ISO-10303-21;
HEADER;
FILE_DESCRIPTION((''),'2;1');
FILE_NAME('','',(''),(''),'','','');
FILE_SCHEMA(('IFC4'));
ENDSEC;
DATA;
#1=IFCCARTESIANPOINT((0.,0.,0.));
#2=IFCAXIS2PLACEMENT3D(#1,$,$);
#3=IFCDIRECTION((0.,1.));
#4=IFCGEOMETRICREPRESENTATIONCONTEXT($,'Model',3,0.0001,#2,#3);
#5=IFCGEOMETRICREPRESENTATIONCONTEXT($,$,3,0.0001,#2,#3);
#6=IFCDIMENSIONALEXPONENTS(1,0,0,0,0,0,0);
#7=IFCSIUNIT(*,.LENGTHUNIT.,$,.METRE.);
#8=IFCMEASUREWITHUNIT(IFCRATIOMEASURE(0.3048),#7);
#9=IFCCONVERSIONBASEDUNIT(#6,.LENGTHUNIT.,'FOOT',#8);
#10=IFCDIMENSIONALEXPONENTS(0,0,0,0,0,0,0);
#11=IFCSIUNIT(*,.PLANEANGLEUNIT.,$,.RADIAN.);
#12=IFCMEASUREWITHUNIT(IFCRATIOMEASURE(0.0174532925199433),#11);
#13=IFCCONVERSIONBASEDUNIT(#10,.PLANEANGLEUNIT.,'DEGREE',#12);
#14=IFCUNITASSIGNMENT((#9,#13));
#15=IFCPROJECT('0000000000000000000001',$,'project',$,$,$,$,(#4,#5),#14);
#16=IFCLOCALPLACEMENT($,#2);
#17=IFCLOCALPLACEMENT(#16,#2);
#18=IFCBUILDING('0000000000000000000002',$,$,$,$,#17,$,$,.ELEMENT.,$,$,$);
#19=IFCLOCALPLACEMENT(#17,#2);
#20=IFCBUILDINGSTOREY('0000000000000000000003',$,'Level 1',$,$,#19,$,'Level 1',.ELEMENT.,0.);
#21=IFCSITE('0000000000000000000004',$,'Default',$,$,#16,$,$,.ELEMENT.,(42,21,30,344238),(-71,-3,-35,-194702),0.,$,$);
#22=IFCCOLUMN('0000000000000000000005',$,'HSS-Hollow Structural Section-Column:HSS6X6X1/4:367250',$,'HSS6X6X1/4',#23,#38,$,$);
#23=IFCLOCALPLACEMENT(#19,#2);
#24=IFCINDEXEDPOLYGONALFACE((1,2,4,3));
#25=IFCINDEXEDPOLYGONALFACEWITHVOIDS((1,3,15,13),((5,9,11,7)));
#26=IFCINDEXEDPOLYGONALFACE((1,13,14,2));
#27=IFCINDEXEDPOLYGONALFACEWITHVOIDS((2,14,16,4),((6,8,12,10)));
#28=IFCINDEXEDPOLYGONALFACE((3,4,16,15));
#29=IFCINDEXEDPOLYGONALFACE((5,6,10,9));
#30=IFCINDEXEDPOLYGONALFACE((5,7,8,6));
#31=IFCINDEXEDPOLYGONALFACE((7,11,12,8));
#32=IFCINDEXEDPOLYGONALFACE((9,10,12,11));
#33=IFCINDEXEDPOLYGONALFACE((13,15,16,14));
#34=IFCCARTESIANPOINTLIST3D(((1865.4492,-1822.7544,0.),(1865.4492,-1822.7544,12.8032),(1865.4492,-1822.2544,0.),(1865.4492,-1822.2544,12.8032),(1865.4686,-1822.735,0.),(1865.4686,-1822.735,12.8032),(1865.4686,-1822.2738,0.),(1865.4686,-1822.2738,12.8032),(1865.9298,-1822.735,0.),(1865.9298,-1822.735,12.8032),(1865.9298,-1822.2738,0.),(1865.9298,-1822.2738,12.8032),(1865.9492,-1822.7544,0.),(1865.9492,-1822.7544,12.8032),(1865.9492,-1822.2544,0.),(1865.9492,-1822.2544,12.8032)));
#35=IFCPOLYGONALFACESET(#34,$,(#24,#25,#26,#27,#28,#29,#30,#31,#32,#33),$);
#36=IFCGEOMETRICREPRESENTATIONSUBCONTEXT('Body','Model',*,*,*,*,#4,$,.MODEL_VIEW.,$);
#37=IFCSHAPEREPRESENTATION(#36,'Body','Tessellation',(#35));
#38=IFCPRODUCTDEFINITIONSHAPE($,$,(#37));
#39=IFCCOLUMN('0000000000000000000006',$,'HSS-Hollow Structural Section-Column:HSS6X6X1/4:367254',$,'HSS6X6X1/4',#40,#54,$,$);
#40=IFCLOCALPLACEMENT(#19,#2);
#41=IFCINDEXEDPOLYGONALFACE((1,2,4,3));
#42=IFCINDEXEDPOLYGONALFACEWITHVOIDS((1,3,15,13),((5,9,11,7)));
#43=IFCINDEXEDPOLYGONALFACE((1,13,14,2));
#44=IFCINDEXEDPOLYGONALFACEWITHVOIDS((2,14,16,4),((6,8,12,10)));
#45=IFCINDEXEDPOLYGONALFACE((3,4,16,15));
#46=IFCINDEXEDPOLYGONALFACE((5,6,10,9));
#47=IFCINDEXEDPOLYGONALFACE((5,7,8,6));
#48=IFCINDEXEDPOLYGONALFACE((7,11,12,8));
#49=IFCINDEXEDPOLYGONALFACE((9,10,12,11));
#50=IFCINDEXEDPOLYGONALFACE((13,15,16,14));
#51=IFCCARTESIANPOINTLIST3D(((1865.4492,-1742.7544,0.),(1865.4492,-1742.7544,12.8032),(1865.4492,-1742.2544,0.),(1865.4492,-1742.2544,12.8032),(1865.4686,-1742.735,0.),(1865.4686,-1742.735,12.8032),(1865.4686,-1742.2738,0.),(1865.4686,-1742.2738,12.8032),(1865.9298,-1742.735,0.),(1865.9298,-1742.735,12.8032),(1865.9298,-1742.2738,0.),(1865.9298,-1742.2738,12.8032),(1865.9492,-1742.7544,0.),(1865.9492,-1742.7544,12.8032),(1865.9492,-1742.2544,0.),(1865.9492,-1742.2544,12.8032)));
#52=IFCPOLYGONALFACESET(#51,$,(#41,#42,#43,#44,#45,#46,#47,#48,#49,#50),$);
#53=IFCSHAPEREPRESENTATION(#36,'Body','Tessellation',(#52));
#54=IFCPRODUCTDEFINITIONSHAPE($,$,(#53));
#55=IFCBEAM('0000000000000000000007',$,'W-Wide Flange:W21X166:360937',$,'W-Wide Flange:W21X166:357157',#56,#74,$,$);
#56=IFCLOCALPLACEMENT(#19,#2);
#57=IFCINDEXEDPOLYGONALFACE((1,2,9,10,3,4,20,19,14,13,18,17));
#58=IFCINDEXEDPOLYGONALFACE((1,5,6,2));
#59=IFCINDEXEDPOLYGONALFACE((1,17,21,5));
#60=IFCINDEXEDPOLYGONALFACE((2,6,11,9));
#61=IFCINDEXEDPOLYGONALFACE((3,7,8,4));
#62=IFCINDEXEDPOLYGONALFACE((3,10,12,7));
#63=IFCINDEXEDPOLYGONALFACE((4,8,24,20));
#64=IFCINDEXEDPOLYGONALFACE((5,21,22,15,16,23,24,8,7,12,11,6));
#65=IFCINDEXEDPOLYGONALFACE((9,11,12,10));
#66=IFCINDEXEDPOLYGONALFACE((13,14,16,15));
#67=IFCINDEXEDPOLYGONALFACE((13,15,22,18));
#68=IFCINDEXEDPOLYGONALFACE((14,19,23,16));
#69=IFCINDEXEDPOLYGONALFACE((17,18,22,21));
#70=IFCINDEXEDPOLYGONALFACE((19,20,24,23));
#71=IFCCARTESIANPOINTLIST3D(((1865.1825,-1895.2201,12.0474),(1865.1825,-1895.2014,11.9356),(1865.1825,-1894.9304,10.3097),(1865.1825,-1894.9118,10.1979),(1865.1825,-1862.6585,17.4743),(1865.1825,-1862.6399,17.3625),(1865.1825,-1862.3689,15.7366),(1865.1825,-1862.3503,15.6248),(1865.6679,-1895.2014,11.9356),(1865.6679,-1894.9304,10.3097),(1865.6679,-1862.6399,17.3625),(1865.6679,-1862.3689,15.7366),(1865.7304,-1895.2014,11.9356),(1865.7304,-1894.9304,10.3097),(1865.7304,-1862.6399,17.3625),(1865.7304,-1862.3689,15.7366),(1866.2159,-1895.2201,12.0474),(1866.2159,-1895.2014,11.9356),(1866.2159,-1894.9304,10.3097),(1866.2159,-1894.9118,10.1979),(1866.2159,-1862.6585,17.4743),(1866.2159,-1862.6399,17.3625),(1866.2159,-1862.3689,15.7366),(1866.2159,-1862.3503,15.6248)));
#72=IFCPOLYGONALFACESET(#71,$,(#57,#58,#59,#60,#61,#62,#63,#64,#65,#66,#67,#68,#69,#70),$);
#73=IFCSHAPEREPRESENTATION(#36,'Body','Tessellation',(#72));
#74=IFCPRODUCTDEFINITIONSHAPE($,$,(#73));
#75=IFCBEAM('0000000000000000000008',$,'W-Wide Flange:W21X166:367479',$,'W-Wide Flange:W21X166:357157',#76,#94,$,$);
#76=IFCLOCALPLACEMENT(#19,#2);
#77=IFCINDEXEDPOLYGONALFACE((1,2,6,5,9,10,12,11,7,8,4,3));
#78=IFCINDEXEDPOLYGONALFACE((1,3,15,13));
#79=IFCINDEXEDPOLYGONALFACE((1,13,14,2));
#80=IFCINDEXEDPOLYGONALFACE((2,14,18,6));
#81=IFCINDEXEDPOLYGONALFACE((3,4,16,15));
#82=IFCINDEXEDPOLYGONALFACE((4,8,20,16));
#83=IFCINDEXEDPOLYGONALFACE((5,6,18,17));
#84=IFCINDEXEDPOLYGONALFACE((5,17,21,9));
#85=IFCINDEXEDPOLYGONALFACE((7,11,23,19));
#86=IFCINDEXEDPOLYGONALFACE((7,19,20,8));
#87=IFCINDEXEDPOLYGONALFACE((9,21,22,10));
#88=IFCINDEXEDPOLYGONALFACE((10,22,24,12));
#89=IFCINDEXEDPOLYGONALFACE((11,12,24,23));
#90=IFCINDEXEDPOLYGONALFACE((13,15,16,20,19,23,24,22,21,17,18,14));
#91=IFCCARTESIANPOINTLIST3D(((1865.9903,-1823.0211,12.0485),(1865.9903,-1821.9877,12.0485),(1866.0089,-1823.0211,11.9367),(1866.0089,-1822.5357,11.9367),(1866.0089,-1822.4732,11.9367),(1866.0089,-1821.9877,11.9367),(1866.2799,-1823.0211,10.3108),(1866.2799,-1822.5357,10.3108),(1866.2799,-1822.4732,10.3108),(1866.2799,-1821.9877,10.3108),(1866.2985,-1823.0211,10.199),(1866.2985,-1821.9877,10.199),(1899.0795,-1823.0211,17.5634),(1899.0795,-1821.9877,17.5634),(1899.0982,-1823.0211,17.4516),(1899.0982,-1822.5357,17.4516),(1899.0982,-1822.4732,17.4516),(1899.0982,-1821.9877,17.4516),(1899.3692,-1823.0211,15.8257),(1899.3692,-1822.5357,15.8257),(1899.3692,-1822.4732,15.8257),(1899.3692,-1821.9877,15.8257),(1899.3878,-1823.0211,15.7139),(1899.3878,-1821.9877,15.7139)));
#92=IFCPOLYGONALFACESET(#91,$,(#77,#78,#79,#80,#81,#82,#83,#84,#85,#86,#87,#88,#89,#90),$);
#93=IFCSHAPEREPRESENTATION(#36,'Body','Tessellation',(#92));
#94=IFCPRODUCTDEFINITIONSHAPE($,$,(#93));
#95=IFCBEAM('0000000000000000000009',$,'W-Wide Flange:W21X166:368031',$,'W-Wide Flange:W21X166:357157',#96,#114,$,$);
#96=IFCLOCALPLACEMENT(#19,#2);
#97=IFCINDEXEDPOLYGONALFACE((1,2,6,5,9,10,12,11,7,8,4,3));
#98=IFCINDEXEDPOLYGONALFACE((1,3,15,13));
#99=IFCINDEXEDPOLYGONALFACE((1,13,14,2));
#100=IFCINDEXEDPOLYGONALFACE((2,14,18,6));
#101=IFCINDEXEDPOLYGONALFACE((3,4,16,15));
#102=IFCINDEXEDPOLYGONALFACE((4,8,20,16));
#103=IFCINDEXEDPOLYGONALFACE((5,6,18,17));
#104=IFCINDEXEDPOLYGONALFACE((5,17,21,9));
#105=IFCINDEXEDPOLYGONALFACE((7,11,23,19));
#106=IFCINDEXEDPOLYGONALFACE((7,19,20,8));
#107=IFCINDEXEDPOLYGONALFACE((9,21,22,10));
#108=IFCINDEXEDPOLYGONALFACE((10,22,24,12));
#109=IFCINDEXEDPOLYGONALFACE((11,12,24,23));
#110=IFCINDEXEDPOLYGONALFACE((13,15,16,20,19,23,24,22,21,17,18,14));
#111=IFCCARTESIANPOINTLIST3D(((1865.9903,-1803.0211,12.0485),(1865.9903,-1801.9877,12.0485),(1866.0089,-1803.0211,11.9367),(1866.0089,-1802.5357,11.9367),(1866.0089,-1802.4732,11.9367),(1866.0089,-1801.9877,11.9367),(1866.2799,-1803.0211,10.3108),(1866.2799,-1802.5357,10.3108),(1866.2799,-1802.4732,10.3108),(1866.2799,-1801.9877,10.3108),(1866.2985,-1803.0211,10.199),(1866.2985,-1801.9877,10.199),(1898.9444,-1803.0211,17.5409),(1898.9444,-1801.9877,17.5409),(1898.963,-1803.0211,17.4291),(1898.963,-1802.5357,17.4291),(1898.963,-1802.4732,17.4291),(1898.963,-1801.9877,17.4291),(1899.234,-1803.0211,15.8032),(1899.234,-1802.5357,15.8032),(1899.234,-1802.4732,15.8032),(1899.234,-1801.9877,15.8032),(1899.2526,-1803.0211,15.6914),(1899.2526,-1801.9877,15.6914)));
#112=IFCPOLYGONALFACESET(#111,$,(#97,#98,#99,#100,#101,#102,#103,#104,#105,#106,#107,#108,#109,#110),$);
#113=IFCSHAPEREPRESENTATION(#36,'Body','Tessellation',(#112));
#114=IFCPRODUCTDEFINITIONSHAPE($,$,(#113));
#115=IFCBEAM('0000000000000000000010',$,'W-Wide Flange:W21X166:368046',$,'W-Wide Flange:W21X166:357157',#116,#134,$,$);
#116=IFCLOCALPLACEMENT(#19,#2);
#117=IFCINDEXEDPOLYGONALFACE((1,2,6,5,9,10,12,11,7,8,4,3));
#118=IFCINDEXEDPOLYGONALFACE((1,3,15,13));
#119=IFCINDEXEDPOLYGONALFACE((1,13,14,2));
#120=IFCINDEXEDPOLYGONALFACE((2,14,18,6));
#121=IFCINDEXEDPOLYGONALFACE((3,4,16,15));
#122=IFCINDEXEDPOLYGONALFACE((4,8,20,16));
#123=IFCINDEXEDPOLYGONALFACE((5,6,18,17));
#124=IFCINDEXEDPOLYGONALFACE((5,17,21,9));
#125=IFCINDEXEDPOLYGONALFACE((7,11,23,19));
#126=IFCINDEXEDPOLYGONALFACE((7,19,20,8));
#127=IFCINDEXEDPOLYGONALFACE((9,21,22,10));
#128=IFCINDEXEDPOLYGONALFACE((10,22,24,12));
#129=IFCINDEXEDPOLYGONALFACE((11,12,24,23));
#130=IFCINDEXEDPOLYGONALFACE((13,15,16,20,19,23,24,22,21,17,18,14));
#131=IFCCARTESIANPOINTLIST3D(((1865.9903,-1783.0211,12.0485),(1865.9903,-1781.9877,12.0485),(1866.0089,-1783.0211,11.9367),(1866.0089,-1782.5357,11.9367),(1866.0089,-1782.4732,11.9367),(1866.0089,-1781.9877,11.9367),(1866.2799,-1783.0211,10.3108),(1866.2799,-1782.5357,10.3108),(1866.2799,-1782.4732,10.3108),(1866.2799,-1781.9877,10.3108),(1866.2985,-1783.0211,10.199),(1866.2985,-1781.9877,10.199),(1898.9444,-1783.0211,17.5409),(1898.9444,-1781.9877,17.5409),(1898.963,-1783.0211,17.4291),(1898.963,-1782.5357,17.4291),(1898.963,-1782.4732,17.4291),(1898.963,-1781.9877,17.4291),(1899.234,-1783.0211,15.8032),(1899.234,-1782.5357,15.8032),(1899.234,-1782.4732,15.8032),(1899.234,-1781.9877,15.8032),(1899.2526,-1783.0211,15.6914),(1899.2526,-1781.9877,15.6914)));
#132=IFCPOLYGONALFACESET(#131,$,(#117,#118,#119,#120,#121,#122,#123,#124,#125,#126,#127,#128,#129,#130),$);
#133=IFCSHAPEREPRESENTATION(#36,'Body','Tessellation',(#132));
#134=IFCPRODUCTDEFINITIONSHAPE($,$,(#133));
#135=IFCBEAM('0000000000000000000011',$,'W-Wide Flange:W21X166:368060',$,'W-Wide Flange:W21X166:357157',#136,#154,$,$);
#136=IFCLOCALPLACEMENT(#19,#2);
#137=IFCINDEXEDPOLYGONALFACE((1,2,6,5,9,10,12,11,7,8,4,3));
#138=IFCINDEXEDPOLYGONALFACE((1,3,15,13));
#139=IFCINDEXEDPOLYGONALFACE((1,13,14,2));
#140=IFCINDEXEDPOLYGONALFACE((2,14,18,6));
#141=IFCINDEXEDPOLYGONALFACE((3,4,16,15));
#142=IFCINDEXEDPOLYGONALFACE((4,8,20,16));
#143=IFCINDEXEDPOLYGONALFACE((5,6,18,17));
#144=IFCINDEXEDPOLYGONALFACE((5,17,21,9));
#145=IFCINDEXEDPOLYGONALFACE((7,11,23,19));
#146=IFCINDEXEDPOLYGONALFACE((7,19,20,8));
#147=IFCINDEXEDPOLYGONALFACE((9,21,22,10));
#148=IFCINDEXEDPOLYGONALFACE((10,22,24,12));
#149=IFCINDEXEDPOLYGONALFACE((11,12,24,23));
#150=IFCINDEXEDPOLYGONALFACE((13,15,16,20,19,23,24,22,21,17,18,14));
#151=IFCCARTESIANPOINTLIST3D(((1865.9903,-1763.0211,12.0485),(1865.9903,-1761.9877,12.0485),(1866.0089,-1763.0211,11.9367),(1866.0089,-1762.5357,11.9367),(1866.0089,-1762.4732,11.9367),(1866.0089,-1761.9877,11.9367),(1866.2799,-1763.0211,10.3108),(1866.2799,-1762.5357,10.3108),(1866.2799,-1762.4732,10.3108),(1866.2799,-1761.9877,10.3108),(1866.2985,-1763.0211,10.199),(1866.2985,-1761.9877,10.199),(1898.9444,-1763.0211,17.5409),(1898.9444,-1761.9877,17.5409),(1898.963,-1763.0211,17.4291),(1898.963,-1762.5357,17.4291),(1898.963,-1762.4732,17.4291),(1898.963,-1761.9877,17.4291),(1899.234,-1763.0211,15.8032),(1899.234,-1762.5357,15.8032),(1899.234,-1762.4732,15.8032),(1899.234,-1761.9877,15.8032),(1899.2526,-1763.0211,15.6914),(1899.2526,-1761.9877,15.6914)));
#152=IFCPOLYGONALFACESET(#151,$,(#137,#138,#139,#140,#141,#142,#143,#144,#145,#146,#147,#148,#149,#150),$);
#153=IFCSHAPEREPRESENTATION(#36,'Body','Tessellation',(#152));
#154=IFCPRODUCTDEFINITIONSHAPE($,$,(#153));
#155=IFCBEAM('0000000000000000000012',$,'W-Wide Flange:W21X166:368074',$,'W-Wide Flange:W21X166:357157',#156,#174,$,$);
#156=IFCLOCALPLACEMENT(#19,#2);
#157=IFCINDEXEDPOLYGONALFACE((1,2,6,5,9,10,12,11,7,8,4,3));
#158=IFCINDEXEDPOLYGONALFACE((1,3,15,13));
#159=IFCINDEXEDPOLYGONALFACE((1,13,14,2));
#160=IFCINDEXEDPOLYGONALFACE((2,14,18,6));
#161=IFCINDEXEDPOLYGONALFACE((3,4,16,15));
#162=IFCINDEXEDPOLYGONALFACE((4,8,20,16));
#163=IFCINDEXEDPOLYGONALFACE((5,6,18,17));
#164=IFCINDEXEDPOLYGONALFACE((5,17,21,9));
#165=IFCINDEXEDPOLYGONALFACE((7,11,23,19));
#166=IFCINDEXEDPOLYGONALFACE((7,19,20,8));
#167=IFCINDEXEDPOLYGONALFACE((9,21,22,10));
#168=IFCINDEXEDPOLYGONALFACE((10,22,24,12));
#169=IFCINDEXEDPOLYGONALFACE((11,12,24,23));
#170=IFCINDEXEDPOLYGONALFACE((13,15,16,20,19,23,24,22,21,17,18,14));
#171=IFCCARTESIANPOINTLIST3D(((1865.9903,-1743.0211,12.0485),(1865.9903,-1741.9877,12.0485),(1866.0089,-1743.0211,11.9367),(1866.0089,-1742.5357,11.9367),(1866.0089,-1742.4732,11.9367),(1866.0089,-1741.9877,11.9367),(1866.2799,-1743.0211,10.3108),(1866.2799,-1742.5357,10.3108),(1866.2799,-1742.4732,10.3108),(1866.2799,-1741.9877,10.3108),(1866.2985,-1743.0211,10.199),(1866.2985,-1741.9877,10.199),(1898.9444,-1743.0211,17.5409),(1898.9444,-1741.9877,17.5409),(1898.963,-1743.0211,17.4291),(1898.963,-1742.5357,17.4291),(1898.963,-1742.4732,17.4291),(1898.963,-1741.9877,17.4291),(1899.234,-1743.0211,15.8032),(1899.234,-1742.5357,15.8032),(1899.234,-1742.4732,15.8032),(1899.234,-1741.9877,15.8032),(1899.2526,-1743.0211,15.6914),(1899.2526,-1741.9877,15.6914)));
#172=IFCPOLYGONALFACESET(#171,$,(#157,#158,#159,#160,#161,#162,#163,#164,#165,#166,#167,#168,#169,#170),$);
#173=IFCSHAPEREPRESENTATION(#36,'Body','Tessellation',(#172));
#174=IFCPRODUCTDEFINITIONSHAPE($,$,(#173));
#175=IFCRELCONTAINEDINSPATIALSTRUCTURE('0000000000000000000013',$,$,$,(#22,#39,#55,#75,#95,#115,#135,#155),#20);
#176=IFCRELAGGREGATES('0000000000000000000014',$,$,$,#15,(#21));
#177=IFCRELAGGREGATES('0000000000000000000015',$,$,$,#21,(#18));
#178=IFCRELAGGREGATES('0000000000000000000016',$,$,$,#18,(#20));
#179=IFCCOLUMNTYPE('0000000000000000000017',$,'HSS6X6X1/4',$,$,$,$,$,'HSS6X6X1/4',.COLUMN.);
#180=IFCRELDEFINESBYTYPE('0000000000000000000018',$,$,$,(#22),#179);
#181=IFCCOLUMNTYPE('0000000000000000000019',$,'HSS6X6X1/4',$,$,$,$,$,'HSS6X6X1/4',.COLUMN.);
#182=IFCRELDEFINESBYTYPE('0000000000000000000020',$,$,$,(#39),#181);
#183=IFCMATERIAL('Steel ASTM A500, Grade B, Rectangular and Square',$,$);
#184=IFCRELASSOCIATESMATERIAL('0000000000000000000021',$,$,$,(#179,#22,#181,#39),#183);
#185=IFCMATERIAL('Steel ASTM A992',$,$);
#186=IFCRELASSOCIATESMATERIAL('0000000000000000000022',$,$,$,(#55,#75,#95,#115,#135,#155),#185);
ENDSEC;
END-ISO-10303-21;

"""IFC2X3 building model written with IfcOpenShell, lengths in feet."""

from ifc_helpers import new_model, entity, si_unit, converted_unit, direction, frame, frame_2d, origin, place, context, subcontext, project, spatial, polyline, i_section, outline, extrude, source, transform, mapped, material, type_object, type_shapes, element, save


model = new_model("IFC2X3")

# Units and contexts
model_context = context("Model", 3, precision=0.0001, world=origin(), true_north=direction((0.0, 1.0)))
context_of_model = context(None, 3, precision=0.0001, world=origin(), true_north=direction((0.0, 1.0)))
body_context = subcontext(model_context, "Body", "Model", "MODEL_VIEW")
ifc_project = project(units=[converted_unit("LENGTHUNIT", "FOOT", entity("IfcRatioMeasure", 0.3048), si_unit("LENGTHUNIT", "METRE"), dimensions=[1, 0, 0, 0, 0, 0, 0]), converted_unit("PLANEANGLEUNIT", "DEGREE", entity("IfcRatioMeasure", 0.0174532925199433), si_unit("PLANEANGLEUNIT", "RADIAN"), dimensions=[0, 0, 0, 0, 0, 0, 0])], contexts=[model_context, context_of_model])

# Site, building, storey
site_placement = place(None, origin())
site = spatial("IfcSite", under=ifc_project, at=site_placement, Name="Default", CompositionType="ELEMENT", RefLatitude=(42, 21, 30, 344238), RefLongitude=(-71, -3, -35, -194702), RefElevation=0.0)
building_placement = place(site_placement, origin())
building = spatial("IfcBuilding", under=site, at=building_placement, CompositionType="ELEMENT")
storey_placement = place(building_placement, origin())
storey = spatial("IfcBuildingStorey", under=building, at=storey_placement, Name="Level 1", LongName="Level 1", CompositionType="ELEMENT", Elevation=0.0)

# Columns
ifc_material_1 = material(Name="Steel ASTM A500, Grade B, Rectangular and Square")
ifc_material_2 = material(Name="Steel ASTM A992")
column_type_1 = type_object("IfcColumnType", Name="HSS6X6X1/4", ElementType="HSS6X6X1/4", PredefinedType="COLUMN", material=ifc_material_1)
shared_shape_1 = source(origin(), body_context, "Body", "SweptSolid", [
    extrude(outline(polyline([(-0.25, -0.25), (0.25, -0.25), (0.25, 0.25), (-0.25, 0.25), (-0.25, -0.25)]), holes=[polyline([(-0.2306, -0.2306), (-0.2306, 0.2306), (0.2306, 0.2306), (0.2306, -0.2306), (-0.2306, -0.2306)])]), frame((0.25, 0.25, 0.0)), (0.0, 0.0, 1.0), 12.8032),
])
type_shapes(column_type_1, [shared_shape_1])
column_1_placement = place(storey_placement, frame((1865.4492, -1822.7544, 0.0)))
element("IfcColumn", 1, at=column_1_placement, inside=storey, type_object=column_type_1, material=ifc_material_1, Name="HSS-Hollow Structural Section-Column:HSS6X6X1/4:367250", ObjectType="HSS6X6X1/4", context=body_context, shape_type="MappedRepresentation", body=[
    mapped(shared_shape_1, transform((0.0, 0.0, 0.0), scale=1.0)),
])
column_type_2 = type_object("IfcColumnType", Name="HSS6X6X1/4", ElementType="HSS6X6X1/4", PredefinedType="COLUMN", material=ifc_material_1)
shared_shape_2 = source(origin(), body_context, "Body", "SweptSolid", [
    extrude(outline(polyline([(-0.25, -0.25), (0.25, -0.25), (0.25, 0.25), (-0.25, 0.25), (-0.25, -0.25)]), holes=[polyline([(-0.2306, -0.2306), (-0.2306, 0.2306), (0.2306, 0.2306), (0.2306, -0.2306), (-0.2306, -0.2306)])]), frame((0.25, 0.25, 0.0)), (0.0, 0.0, 1.0), 12.8032),
])
type_shapes(column_type_2, [shared_shape_2])
column_2_placement = place(storey_placement, frame((1865.4492, -1742.7544, 0.0)))
element("IfcColumn", 2, at=column_2_placement, inside=storey, type_object=column_type_2, material=ifc_material_1, Name="HSS-Hollow Structural Section-Column:HSS6X6X1/4:367254", ObjectType="HSS6X6X1/4", context=body_context, shape_type="MappedRepresentation", body=[
    mapped(shared_shape_2, transform((0.0, 0.0, 0.0), scale=1.0)),
])

# Beams
beam_1_placement = place(storey_placement, frame((1865.6992, -1895.6585, 11.9743), z_axis=(0.0, -0.164399, 0.986394), x_axis=(0.0, 0.986394, 0.164399)))
element("IfcBeam", 3, at=beam_1_placement, inside=storey, material=ifc_material_2, Name="W-Wide Flange:W21X166:360937", ObjectType="W-Wide Flange:W21X166:357157", context=body_context, shape_type="SweptSolid", body=[
    extrude(i_section(OverallWidth=1.0333, OverallDepth=1.875, WebThickness=0.0625, FlangeThickness=0.1133, at=frame_2d((0.0, 0.0), x_axis=(0.0, 1.0))), frame((0.4445, 0.0, -0.9375), z_axis=(1.0, 0.0, 0.0), x_axis=(0.0, 0.0, -1.0)), (0.0, 0.0, 1.0), 33.0107),
])
beam_2_placement = place(storey_placement, frame((1865.8276, -1822.5044, 12.0214), z_axis=(-0.164399, 0.0, 0.986394), x_axis=(0.986394, 0.0, 0.164399)))
element("IfcBeam", 4, at=beam_2_placement, inside=storey, material=ifc_material_2, Name="W-Wide Flange:W21X166:367479", ObjectType="W-Wide Flange:W21X166:357157", context=body_context, shape_type="SweptSolid", body=[
    extrude(i_section(OverallWidth=1.0333, OverallDepth=1.875, WebThickness=0.0625, FlangeThickness=0.1133, at=frame_2d((0.0, 0.0), x_axis=(0.0, 1.0))), frame((0.165, 0.0, -0.9375), z_axis=(1.0, 0.0, 0.0), x_axis=(0.0, 0.0, -1.0)), (0.0, 0.0, 1.0), 33.5457),
])

# Beams
beam_3_placement = place(storey_placement, frame((1865.8276, -1802.5044, 12.0214), z_axis=(-0.164399, 0.0, 0.986394), x_axis=(0.986394, 0.0, 0.164399)))
element("IfcBeam", 5, at=beam_3_placement, inside=storey, material=ifc_material_2, Name="W-Wide Flange:W21X166:368031", ObjectType="W-Wide Flange:W21X166:357157", context=body_context, shape_type="SweptSolid", body=[
    extrude(i_section(OverallWidth=1.0333, OverallDepth=1.875, WebThickness=0.0625, FlangeThickness=0.1133, at=frame_2d((0.0, 0.0), x_axis=(0.0, 1.0))), frame((0.165, 0.0, -0.9375), z_axis=(1.0, 0.0, 0.0), x_axis=(0.0, 0.0, -1.0)), (0.0, 0.0, 1.0), 33.4087),
])
beam_4_placement = place(storey_placement, frame((1865.8276, -1782.5044, 12.0214), z_axis=(-0.164399, 0.0, 0.986394), x_axis=(0.986394, 0.0, 0.164399)))
element("IfcBeam", 6, at=beam_4_placement, inside=storey, material=ifc_material_2, Name="W-Wide Flange:W21X166:368046", ObjectType="W-Wide Flange:W21X166:357157", context=body_context, shape_type="SweptSolid", body=[
    extrude(i_section(OverallWidth=1.0333, OverallDepth=1.875, WebThickness=0.0625, FlangeThickness=0.1133, at=frame_2d((0.0, 0.0), x_axis=(0.0, 1.0))), frame((0.165, 0.0, -0.9375), z_axis=(1.0, 0.0, 0.0), x_axis=(0.0, 0.0, -1.0)), (0.0, 0.0, 1.0), 33.4087),
])
beam_5_placement = place(storey_placement, frame((1865.8276, -1762.5044, 12.0214), z_axis=(-0.164399, 0.0, 0.986394), x_axis=(0.986394, 0.0, 0.164399)))
element("IfcBeam", 7, at=beam_5_placement, inside=storey, material=ifc_material_2, Name="W-Wide Flange:W21X166:368060", ObjectType="W-Wide Flange:W21X166:357157", context=body_context, shape_type="SweptSolid", body=[
    extrude(i_section(OverallWidth=1.0333, OverallDepth=1.875, WebThickness=0.0625, FlangeThickness=0.1133, at=frame_2d((0.0, 0.0), x_axis=(0.0, 1.0))), frame((0.165, 0.0, -0.9375), z_axis=(1.0, 0.0, 0.0), x_axis=(0.0, 0.0, -1.0)), (0.0, 0.0, 1.0), 33.4087),
])
beam_6_placement = place(storey_placement, frame((1865.8276, -1742.5044, 12.0214), z_axis=(-0.164399, 0.0, 0.986394), x_axis=(0.986394, 0.0, 0.164399)))
element("IfcBeam", 8, at=beam_6_placement, inside=storey, material=ifc_material_2, Name="W-Wide Flange:W21X166:368074", ObjectType="W-Wide Flange:W21X166:357157", context=body_context, shape_type="SweptSolid", body=[
    extrude(i_section(OverallWidth=1.0333, OverallDepth=1.875, WebThickness=0.0625, FlangeThickness=0.1133, at=frame_2d((0.0, 0.0), x_axis=(0.0, 1.0))), frame((0.165, 0.0, -0.9375), z_axis=(1.0, 0.0, 0.0), x_axis=(0.0, 0.0, -1.0)), (0.0, 0.0, 1.0), 33.4087),
])

save(model, "model.ifc")
